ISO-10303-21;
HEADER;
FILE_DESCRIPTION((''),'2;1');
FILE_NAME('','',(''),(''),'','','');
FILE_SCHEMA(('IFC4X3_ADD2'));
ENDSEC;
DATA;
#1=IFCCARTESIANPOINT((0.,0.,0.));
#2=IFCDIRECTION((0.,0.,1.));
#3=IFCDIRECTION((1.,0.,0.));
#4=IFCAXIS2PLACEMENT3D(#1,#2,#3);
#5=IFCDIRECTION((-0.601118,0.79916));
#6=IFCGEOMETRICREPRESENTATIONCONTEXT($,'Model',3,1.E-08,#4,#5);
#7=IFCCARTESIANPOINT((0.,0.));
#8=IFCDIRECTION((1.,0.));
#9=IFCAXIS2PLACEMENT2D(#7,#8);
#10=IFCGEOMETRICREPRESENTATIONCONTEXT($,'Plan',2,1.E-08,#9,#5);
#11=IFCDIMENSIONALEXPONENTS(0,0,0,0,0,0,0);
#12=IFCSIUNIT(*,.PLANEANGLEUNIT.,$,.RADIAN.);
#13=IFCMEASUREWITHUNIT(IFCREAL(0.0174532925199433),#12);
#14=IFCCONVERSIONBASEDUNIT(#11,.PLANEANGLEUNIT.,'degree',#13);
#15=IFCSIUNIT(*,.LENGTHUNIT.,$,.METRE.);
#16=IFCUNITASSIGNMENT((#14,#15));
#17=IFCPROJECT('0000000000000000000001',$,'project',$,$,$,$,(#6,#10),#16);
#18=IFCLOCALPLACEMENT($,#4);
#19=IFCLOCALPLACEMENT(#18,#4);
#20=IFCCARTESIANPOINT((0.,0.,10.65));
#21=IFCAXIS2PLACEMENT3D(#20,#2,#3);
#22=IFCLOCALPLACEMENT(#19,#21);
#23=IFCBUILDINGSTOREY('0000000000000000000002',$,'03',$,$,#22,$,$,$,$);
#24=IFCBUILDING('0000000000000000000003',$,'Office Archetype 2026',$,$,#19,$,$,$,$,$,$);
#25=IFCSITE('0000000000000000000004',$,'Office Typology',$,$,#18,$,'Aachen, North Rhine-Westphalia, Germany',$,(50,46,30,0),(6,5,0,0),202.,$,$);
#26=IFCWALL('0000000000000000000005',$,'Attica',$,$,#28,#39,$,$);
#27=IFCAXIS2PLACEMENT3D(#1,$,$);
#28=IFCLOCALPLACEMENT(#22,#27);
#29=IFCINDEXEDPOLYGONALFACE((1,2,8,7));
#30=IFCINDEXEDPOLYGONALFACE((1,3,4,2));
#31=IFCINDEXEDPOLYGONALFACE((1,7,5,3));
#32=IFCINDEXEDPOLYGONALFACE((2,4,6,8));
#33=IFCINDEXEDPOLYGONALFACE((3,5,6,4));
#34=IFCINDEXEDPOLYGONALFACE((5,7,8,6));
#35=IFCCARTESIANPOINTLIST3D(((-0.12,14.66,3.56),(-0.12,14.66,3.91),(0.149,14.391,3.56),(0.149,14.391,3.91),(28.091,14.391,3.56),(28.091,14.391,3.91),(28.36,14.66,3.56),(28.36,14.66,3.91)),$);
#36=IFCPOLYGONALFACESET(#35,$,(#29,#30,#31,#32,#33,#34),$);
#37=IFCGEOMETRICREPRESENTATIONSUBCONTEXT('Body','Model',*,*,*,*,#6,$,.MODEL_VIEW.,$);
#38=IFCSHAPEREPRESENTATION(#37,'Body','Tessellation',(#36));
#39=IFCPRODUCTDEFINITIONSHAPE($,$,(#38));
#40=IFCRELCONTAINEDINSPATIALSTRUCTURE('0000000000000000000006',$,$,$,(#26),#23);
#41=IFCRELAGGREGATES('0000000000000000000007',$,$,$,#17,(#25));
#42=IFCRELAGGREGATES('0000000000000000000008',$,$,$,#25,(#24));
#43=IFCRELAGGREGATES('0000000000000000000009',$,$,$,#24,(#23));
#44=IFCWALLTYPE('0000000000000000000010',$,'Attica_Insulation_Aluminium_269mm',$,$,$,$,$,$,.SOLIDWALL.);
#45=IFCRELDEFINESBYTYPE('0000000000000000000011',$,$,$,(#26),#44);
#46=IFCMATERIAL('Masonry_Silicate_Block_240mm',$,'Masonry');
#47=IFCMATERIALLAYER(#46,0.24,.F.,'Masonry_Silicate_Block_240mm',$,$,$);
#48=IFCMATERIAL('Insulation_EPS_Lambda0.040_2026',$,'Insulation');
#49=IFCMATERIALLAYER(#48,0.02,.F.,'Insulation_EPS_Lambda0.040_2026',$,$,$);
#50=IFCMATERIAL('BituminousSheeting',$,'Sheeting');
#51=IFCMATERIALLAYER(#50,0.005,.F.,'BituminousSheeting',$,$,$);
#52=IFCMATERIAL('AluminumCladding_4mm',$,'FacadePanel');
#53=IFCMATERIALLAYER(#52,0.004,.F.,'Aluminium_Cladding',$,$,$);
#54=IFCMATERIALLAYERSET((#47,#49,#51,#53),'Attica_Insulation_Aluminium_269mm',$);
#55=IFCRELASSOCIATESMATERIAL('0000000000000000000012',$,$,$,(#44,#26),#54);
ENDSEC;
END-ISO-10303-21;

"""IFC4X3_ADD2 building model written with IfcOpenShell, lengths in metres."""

from ifc_helpers import new_model, entity, si_unit, converted_unit, direction, frame, origin_with_axes, origin_2d_with_axis, place, context, subcontext, project, spatial, line, indexed_curve, outline, extrude, material, layer, layer_set, layer_usage, type_object, element, save


model = new_model("IFC4X3_ADD2")

# Units and contexts
model_context = context("Model", 3, precision=1e-08, world=origin_with_axes(), true_north=direction((-0.601118, 0.79916)))
plan_context = context("Plan", 2, precision=1e-08, world=origin_2d_with_axis(), true_north=direction((-0.601118, 0.79916)))
body_context = subcontext(model_context, "Body", "Model", "MODEL_VIEW")
ifc_project = project(units=[converted_unit("PLANEANGLEUNIT", "degree", entity("IfcReal", 0.0174532925199433), si_unit("PLANEANGLEUNIT", "RADIAN"), dimensions=[0, 0, 0, 0, 0, 0, 0]), si_unit("LENGTHUNIT", "METRE")], contexts=[model_context, plan_context])

# Site, building, storey
site_placement = place(None, origin_with_axes())
site = spatial("IfcSite", under=ifc_project, at=site_placement, Name="Office Typology", LongName="Aachen, North Rhine-Westphalia, Germany", RefLatitude=(50, 46, 30, 0), RefLongitude=(6, 5, 0, 0), RefElevation=202.0)
building_placement = place(site_placement, origin_with_axes())
building = spatial("IfcBuilding", under=site, at=building_placement, Name="Office Archetype 2026")
storey_placement = place(building_placement, frame((0.0, 0.0, 10.65), z_axis=(0.0, 0.0, 1.0), x_axis=(1.0, 0.0, 0.0)))
storey = spatial("IfcBuildingStorey", under=building, at=storey_placement, Name="03")

# Shared definitions
ifc_material_1 = material(Name="Masonry_Silicate_Block_240mm", Category="Masonry")

# Wall
ifc_layer_1 = layer(ifc_material_1, 0.24, ventilated=False, Name="Masonry_Silicate_Block_240mm")
ifc_material_2 = material(Name="Insulation_EPS_Lambda0.040_2026", Category="Insulation")
ifc_layer_2 = layer(ifc_material_2, 0.02, ventilated=False, Name="Insulation_EPS_Lambda0.040_2026")
ifc_material_3 = material(Name="BituminousSheeting", Category="Sheeting")
ifc_layer_3 = layer(ifc_material_3, 0.005, ventilated=False, Name="BituminousSheeting")
ifc_material_4 = material(Name="AluminumCladding_4mm", Category="FacadePanel")
ifc_layer_4 = layer(ifc_material_4, 0.004, ventilated=False, Name="Aluminium_Cladding")
ifc_layer_set_1 = layer_set([ifc_layer_1, ifc_layer_2, ifc_layer_3, ifc_layer_4], Name="Attica_Insulation_Aluminium_269mm")
ifc_layer_usage_1 = layer_usage(ifc_layer_set_1, "AXIS2", "POSITIVE", 0.0)
wall_type_1 = type_object("IfcWallType", Name="Attica_Insulation_Aluminium_269mm", PredefinedType="SOLIDWALL", material=ifc_layer_set_1)
wall_1_placement = place(storey_placement, frame((28.36, 14.66, 3.56), z_axis=(0.0, 0.0, 1.0), x_axis=(-1.0, 0.0, 0.0)))
element("IfcWall", 1, at=wall_1_placement, inside=storey, type_object=wall_type_1, material=ifc_layer_usage_1, Name="Attica", context=body_context, shape_type="SweptSolid", body=[
    extrude(outline(indexed_curve([(0.0, 0.0), (0.269, 0.269), (28.211, 0.269), (28.48, 0.0)], segments=[line(1, 2, 3, 4, 1)])), origin_with_axes(), (0.0, 0.0, 1.0), 0.35),
])

save(model, "model.ifc")
